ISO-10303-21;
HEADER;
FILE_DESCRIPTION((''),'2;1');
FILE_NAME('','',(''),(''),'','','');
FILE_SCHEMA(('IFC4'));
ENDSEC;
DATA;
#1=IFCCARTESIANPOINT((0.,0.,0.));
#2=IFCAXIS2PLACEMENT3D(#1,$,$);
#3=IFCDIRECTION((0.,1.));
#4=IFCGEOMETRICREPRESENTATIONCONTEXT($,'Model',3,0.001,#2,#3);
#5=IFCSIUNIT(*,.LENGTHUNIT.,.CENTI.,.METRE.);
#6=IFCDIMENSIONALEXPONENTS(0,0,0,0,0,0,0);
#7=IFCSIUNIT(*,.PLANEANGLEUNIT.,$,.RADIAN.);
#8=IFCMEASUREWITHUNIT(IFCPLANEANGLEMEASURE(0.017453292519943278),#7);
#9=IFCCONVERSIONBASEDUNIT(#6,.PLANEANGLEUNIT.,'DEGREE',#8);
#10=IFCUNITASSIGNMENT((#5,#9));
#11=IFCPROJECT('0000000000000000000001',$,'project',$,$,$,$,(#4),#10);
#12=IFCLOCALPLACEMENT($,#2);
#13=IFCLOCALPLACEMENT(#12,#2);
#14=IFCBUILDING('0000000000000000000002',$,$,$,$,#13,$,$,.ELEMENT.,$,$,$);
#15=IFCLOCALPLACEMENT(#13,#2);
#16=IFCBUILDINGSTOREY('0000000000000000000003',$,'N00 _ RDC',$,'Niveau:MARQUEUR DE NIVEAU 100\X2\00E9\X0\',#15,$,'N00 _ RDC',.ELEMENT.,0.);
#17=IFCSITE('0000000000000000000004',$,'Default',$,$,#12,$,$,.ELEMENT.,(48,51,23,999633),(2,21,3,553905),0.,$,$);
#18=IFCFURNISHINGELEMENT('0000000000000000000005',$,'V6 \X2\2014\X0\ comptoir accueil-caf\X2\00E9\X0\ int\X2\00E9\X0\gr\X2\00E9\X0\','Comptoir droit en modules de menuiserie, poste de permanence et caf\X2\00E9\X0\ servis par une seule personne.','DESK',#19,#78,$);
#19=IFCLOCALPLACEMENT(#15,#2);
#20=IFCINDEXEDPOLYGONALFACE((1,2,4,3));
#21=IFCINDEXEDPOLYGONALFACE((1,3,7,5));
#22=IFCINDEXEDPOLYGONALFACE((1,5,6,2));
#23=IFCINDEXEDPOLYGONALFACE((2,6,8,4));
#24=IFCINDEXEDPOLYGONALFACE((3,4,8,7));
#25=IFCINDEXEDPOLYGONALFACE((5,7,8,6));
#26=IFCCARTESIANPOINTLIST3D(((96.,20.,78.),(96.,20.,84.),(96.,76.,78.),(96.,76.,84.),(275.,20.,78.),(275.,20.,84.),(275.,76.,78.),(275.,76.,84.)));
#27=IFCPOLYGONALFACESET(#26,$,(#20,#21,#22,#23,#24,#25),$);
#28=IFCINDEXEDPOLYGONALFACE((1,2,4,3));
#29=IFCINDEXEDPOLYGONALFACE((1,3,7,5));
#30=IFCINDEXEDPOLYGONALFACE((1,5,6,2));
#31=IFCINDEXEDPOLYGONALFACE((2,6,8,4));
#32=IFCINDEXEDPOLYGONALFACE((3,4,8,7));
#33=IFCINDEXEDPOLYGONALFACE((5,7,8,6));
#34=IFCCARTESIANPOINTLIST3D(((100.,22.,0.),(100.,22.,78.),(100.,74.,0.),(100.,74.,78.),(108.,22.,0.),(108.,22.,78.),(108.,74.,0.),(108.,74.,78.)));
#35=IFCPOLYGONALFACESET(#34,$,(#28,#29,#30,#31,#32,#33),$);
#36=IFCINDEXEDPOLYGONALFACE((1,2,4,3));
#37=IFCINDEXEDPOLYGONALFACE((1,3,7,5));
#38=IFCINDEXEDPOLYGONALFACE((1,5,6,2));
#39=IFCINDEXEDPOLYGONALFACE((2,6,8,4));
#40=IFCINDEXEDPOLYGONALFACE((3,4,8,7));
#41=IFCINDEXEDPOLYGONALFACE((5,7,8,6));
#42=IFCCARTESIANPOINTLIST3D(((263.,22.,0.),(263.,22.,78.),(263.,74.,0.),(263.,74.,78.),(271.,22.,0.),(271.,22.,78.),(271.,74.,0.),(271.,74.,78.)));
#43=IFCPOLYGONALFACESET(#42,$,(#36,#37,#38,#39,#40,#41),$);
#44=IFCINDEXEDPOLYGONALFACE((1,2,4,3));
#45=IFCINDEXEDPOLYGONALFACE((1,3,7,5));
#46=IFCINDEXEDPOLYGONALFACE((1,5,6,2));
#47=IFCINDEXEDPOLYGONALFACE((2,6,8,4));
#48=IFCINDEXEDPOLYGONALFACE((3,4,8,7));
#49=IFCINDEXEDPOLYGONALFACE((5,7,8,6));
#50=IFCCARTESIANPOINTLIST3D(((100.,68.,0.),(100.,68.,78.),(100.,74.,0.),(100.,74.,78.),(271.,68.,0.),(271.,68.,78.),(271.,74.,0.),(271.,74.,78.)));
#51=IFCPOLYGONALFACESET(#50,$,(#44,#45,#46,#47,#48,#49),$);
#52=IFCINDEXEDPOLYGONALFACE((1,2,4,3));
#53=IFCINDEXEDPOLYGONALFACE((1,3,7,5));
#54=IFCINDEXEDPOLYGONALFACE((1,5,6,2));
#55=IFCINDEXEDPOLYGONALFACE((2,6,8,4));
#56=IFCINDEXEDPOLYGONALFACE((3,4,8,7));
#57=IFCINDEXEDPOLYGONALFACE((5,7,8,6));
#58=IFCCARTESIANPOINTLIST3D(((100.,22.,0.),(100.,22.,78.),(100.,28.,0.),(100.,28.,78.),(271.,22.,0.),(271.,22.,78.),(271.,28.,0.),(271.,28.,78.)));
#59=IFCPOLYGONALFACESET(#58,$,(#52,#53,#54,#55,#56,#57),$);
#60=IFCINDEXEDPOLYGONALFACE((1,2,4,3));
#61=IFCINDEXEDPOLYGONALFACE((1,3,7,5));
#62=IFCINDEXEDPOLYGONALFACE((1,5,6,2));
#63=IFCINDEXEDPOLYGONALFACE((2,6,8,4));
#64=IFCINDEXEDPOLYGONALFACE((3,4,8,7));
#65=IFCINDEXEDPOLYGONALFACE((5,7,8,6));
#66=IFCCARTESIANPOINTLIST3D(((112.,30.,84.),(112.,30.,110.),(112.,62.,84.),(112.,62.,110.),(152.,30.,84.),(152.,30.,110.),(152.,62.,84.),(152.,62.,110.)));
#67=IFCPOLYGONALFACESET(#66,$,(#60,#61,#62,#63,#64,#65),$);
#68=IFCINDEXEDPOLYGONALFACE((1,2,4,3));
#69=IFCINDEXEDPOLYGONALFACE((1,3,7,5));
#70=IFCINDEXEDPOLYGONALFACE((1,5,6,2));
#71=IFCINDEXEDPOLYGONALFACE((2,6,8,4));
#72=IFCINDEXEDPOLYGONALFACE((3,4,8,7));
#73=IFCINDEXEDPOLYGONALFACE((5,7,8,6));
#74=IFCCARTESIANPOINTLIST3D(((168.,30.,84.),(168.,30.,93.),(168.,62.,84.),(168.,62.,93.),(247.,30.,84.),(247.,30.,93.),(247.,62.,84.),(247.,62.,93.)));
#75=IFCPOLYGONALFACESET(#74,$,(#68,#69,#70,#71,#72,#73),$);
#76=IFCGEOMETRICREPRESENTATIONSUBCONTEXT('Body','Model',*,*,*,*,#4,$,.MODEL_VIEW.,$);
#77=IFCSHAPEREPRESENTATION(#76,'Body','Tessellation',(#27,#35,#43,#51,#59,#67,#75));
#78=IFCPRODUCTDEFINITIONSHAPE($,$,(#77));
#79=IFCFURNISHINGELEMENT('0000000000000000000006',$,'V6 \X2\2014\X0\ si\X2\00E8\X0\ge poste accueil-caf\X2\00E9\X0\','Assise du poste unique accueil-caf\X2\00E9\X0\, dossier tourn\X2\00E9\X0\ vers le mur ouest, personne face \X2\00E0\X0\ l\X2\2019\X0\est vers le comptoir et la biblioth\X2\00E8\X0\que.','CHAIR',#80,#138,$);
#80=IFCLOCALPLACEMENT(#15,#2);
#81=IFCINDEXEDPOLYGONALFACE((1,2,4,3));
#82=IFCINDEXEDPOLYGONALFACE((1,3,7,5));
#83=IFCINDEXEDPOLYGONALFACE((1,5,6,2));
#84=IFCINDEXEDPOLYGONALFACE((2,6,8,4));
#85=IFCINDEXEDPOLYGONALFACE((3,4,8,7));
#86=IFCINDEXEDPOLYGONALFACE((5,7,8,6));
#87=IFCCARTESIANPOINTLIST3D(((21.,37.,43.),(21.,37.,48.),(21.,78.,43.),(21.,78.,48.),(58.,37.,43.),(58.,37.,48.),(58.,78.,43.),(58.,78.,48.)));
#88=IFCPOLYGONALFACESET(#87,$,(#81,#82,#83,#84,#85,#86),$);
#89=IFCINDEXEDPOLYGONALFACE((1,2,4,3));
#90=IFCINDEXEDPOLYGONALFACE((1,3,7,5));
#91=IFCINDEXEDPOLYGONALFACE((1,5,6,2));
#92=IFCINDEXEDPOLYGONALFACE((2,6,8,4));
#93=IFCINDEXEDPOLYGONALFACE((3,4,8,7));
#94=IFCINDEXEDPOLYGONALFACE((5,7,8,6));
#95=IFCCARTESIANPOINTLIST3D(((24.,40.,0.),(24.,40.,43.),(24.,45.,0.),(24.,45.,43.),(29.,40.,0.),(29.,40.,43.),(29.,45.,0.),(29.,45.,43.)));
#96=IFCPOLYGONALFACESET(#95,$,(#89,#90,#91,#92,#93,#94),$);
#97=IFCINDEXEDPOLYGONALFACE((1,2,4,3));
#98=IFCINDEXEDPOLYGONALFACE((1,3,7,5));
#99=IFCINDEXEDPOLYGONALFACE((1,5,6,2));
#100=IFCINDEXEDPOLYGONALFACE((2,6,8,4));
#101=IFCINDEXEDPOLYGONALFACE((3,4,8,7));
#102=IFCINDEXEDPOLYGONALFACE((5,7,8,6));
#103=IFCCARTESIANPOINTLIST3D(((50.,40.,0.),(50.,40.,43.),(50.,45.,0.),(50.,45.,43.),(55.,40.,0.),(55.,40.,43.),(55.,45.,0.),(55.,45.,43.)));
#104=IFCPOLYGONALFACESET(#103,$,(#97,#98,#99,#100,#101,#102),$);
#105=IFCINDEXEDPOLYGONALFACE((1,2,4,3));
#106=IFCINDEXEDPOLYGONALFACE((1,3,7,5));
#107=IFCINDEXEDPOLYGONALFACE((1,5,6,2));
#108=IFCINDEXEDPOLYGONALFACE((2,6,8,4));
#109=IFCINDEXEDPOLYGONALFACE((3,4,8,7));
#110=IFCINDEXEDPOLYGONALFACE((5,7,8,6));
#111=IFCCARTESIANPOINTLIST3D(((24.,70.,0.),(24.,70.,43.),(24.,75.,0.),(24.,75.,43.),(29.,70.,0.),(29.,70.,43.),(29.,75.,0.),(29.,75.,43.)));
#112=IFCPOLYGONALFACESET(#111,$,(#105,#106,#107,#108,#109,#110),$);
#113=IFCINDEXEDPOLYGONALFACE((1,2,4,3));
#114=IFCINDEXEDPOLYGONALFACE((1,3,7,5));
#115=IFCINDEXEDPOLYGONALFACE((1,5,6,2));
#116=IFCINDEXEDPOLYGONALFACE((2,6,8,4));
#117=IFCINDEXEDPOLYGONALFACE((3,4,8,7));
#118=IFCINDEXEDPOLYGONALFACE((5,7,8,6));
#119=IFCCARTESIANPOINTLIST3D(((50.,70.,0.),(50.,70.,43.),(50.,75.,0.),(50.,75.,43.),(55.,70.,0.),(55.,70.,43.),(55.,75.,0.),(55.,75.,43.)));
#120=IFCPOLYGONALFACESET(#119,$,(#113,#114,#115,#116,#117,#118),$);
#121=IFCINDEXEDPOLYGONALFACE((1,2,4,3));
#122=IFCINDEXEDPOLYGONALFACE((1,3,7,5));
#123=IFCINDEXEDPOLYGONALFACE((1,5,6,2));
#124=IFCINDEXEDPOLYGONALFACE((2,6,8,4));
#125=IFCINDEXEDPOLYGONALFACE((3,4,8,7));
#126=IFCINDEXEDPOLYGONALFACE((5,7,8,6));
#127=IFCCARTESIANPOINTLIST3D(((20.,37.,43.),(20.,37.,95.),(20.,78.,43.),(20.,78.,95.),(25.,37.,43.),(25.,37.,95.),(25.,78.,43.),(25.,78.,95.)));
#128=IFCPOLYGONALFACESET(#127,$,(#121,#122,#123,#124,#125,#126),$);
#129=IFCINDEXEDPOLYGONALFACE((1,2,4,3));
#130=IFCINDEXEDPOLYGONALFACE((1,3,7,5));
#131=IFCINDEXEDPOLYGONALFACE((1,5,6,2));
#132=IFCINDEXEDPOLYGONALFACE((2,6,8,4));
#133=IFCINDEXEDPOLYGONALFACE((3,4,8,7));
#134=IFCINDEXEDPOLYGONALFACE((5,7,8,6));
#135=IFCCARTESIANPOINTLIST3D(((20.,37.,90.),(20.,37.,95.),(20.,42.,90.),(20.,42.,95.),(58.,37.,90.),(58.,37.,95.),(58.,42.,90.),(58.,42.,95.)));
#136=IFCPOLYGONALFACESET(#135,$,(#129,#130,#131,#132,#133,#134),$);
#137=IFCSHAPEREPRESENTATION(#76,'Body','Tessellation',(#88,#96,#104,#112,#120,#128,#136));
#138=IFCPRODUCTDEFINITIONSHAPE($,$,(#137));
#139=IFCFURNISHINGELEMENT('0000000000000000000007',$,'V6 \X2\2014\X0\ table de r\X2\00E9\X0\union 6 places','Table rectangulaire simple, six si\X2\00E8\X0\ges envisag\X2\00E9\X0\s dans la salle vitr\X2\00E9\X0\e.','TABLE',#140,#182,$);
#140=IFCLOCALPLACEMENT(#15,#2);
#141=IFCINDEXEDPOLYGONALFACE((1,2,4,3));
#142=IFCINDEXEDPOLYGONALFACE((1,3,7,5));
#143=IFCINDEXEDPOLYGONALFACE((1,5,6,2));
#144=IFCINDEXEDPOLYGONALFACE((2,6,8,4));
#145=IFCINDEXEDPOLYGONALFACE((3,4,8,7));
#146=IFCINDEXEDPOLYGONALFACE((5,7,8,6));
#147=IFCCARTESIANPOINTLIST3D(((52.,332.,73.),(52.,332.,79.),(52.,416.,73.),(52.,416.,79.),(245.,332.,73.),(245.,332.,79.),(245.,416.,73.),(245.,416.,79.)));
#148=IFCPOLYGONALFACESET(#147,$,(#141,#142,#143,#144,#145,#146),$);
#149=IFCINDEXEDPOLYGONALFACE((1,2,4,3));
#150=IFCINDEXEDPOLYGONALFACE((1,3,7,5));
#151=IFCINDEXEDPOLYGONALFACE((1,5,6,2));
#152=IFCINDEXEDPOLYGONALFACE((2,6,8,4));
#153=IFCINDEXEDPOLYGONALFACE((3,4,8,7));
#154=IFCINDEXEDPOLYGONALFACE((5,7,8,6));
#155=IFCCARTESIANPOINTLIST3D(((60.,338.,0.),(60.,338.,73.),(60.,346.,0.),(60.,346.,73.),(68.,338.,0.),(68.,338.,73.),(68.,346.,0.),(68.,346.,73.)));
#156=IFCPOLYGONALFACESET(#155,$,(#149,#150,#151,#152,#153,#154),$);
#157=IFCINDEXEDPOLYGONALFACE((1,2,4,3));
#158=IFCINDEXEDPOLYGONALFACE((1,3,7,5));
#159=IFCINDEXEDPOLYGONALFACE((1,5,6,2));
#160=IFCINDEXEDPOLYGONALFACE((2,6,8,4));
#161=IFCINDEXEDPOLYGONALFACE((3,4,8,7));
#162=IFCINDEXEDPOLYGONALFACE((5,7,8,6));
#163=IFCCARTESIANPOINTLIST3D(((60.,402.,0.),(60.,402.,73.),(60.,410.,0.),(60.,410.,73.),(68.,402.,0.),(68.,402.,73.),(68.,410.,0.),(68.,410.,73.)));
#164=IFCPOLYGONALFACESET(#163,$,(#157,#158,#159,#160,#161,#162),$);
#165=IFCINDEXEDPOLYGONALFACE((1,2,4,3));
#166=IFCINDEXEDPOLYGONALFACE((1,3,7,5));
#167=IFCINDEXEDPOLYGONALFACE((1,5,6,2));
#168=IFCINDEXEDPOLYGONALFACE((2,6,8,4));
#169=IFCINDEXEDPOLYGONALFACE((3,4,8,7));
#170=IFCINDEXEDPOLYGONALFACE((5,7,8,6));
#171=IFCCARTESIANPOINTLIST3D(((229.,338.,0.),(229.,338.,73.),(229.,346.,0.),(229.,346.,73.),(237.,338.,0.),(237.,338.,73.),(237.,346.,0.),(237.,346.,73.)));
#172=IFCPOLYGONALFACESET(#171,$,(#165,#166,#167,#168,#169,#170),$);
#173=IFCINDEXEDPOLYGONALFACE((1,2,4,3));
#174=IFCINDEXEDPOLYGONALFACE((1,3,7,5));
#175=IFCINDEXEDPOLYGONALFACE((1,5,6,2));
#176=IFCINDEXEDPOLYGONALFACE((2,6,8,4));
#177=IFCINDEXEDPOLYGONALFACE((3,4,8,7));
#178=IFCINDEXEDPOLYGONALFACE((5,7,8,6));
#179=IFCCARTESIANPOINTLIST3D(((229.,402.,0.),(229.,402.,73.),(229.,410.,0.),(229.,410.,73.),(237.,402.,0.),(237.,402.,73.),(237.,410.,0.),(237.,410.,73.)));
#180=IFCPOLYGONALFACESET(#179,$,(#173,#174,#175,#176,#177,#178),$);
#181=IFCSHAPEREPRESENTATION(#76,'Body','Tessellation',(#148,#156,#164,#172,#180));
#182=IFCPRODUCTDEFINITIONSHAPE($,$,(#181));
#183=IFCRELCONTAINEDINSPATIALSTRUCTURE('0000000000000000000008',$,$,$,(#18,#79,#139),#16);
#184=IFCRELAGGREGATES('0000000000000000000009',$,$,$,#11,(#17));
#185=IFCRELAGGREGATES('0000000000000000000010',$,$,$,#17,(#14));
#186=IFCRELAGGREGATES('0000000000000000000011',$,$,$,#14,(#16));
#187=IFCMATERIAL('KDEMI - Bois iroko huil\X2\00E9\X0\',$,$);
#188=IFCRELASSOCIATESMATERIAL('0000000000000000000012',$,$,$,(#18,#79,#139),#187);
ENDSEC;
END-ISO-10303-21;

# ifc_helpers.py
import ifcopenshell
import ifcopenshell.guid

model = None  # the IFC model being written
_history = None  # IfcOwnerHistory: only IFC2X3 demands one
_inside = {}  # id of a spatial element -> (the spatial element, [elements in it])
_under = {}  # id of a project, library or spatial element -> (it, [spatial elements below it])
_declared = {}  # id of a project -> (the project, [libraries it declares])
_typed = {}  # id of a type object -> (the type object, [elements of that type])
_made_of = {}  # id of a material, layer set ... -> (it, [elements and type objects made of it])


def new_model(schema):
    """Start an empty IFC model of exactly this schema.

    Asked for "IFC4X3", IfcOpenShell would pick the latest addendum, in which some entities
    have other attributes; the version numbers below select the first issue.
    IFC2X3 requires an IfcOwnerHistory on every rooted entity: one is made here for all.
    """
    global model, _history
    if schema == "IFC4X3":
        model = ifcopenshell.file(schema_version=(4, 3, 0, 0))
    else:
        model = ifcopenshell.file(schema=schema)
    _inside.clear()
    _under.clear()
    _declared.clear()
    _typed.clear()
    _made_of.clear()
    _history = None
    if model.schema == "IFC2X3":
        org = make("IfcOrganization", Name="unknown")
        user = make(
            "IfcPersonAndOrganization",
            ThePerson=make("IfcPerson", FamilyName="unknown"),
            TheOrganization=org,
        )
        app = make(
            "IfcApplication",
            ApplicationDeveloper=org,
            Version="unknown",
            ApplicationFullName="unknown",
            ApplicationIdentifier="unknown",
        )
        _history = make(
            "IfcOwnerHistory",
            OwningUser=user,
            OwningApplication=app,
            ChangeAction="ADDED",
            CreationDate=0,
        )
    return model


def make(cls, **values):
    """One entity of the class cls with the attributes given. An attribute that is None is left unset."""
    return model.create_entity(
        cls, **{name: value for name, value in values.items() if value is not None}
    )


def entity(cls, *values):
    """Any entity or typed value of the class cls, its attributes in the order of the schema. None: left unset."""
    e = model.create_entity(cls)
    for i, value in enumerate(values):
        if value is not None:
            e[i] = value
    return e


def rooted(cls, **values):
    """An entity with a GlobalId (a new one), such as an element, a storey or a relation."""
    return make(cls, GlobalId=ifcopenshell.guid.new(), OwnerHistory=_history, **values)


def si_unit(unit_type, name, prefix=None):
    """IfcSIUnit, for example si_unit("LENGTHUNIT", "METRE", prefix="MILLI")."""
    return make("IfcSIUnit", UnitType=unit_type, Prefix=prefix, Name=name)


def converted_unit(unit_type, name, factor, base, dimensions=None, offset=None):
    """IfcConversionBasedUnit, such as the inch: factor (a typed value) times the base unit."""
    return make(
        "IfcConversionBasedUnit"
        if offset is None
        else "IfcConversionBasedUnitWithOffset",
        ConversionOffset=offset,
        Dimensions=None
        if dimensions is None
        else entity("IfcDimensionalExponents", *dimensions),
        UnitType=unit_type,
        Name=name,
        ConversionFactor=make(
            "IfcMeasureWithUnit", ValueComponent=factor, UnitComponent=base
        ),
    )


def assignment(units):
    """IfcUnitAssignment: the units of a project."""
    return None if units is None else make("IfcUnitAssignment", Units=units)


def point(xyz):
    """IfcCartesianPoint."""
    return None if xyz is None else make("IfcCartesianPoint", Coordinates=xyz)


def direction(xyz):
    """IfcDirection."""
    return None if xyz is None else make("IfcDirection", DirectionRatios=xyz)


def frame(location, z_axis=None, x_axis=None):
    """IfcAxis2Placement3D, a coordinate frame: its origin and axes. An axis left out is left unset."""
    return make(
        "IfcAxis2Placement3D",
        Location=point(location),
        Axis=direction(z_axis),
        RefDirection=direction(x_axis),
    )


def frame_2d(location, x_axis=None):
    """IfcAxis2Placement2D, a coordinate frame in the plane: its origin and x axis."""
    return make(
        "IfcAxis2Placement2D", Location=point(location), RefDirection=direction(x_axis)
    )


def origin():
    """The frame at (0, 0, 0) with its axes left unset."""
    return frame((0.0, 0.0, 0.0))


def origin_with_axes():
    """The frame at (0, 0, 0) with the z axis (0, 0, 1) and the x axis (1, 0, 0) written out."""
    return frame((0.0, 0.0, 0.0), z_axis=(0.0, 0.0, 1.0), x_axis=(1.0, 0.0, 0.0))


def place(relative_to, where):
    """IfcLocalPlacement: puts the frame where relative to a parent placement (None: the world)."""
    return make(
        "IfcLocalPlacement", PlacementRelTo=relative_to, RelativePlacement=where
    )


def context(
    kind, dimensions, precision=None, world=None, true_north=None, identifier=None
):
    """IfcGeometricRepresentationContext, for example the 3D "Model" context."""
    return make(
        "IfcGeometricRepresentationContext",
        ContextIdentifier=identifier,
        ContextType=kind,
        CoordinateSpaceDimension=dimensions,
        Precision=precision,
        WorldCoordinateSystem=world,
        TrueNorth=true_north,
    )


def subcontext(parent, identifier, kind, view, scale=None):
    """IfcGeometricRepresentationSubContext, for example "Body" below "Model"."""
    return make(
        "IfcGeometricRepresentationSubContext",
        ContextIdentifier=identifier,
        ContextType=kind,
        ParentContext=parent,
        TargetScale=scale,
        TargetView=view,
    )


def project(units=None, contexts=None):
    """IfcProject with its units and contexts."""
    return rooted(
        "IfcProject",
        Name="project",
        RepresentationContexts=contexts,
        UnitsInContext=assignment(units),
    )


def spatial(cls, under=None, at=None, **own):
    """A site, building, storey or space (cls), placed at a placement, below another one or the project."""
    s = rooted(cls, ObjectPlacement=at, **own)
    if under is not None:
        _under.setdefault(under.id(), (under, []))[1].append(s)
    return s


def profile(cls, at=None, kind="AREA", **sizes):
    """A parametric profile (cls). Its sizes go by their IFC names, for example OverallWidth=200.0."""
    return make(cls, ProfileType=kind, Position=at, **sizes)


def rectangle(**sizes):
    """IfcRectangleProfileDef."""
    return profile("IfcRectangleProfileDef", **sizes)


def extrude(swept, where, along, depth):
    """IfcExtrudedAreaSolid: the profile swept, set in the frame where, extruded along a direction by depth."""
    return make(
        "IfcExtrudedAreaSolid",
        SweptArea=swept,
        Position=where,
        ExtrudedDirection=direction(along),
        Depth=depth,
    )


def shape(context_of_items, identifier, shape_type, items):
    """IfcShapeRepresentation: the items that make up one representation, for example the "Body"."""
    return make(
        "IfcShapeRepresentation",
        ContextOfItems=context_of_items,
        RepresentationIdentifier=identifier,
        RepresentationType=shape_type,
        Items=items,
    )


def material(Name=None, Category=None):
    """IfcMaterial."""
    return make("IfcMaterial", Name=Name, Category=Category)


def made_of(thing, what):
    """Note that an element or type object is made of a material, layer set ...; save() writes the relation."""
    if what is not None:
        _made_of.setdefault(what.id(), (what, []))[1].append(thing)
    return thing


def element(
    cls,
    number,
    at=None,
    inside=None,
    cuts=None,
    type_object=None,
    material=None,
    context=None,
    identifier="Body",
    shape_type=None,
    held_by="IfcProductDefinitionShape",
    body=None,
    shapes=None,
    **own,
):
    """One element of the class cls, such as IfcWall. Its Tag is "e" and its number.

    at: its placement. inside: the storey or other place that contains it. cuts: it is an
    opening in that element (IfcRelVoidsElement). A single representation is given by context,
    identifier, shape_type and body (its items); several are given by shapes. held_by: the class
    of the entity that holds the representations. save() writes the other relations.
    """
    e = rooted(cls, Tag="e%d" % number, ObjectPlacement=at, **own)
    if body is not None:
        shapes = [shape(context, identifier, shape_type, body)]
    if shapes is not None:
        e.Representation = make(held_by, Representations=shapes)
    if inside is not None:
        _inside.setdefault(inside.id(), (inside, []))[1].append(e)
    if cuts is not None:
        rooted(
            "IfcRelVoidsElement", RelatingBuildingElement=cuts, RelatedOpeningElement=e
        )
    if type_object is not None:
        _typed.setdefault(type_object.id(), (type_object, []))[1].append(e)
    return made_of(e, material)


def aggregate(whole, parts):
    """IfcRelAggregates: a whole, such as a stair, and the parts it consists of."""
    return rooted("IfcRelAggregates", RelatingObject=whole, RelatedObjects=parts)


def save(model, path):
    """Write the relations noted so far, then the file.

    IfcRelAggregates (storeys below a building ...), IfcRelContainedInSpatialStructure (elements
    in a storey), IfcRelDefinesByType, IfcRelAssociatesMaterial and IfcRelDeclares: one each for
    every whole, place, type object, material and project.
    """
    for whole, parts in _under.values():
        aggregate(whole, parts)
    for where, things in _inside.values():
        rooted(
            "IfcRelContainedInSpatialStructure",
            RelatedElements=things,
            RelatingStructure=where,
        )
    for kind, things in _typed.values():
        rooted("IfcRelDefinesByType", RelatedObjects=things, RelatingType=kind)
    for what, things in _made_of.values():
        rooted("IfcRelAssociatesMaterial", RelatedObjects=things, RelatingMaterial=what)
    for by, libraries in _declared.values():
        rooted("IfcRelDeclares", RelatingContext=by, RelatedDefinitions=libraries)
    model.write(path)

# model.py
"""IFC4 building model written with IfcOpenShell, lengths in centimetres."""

from ifc_helpers import new_model, entity, si_unit, converted_unit, direction, frame, frame_2d, origin, origin_with_axes, place, context, subcontext, project, spatial, rectangle, extrude, material, element, save


model = new_model("IFC4")

# Units and contexts
model_context = context("Model", 3, precision=0.001, world=origin(), true_north=direction((0.0, 1.0)))
body_context = subcontext(model_context, "Body", "Model", "MODEL_VIEW")
ifc_project = project(units=[si_unit("LENGTHUNIT", "METRE", prefix="CENTI"), converted_unit("PLANEANGLEUNIT", "DEGREE", entity("IfcPlaneAngleMeasure", 0.017453292519943278), si_unit("PLANEANGLEUNIT", "RADIAN"), dimensions=[0, 0, 0, 0, 0, 0, 0])], contexts=[model_context])

# Site, building, storey
site_placement = place(None, origin())
site = spatial("IfcSite", under=ifc_project, at=site_placement, Name="Default", CompositionType="ELEMENT", RefLatitude=(48, 51, 23, 999633), RefLongitude=(2, 21, 3, 553905), RefElevation=0.0)
building_placement = place(site_placement, origin())
building = spatial("IfcBuilding", under=site, at=building_placement, CompositionType="ELEMENT")
storey_placement = place(building_placement, origin())
storey = spatial("IfcBuildingStorey", under=building, at=storey_placement, Name="N00 _ RDC", ObjectType="Niveau:MARQUEUR DE NIVEAU 100é", LongName="N00 _ RDC", CompositionType="ELEMENT", Elevation=0.0)

# Furnishing elements
ifc_material_1 = material(Name="KDEMI - Bois iroko huilé")
furnishing_1_placement = place(storey_placement, origin_with_axes())
element("IfcFurnishingElement", 1, at=furnishing_1_placement, inside=storey, material=ifc_material_1, Name="V6 — comptoir accueil-café intégré", Description="Comptoir droit en modules de menuiserie, poste de permanence et café servis par une seule personne.", ObjectType="DESK", context=body_context, shape_type="SweptSolid", body=[
    extrude(rectangle(XDim=179.0, YDim=56.0, at=frame_2d((185.5, 48.0))), frame((0.0, 0.0, 78.0)), (0.0, 0.0, 1.0), 6.0),
    extrude(rectangle(XDim=8.0, YDim=52.0, at=frame_2d((104.0, 48.0))), origin(), (0.0, 0.0, 1.0), 78.0),
    extrude(rectangle(XDim=8.0, YDim=52.0, at=frame_2d((267.0, 48.0))), origin(), (0.0, 0.0, 1.0), 78.0),
    extrude(rectangle(XDim=171.0, YDim=6.0, at=frame_2d((185.5, 71.0))), origin(), (0.0, 0.0, 1.0), 78.0),
    extrude(rectangle(XDim=171.0, YDim=6.0, at=frame_2d((185.5, 25.0))), origin(), (0.0, 0.0, 1.0), 78.0),
    extrude(rectangle(XDim=40.0, YDim=32.0, at=frame_2d((132.0, 46.0))), frame((0.0, 0.0, 84.0)), (0.0, 0.0, 1.0), 26.0),
    extrude(rectangle(XDim=79.0, YDim=32.0, at=frame_2d((207.5, 46.0))), frame((0.0, 0.0, 84.0)), (0.0, 0.0, 1.0), 9.0),
])
furnishing_2_placement = place(storey_placement, origin_with_axes())
element("IfcFurnishingElement", 2, at=furnishing_2_placement, inside=storey, material=ifc_material_1, Name="V6 — siège poste accueil-café", Description="Assise du poste unique accueil-café, dossier tourné vers le mur ouest, personne face à l’est vers le comptoir et la bibliothèque.", ObjectType="CHAIR", context=body_context, shape_type="SweptSolid", body=[
    extrude(rectangle(XDim=37.0, YDim=41.0, at=frame_2d((39.5, 57.5))), frame((0.0, 0.0, 43.0)), (0.0, 0.0, 1.0), 5.0),
    extrude(rectangle(XDim=5.0, YDim=5.0, at=frame_2d((26.5, 42.5))), origin(), (0.0, 0.0, 1.0), 43.0),
    extrude(rectangle(XDim=5.0, YDim=5.0, at=frame_2d((52.5, 42.5))), origin(), (0.0, 0.0, 1.0), 43.0),
    extrude(rectangle(XDim=5.0, YDim=5.0, at=frame_2d((26.5, 72.5))), origin(), (0.0, 0.0, 1.0), 43.0),
    extrude(rectangle(XDim=5.0, YDim=5.0, at=frame_2d((52.5, 72.5))), origin(), (0.0, 0.0, 1.0), 43.0),
    extrude(rectangle(XDim=5.0, YDim=41.0, at=frame_2d((22.5, 57.5))), frame((0.0, 0.0, 43.0)), (0.0, 0.0, 1.0), 52.0),
    extrude(rectangle(XDim=38.0, YDim=5.0, at=frame_2d((39.0, 39.5))), frame((0.0, 0.0, 90.0)), (0.0, 0.0, 1.0), 5.0),
])
furnishing_3_placement = place(storey_placement, origin_with_axes())
element("IfcFurnishingElement", 3, at=furnishing_3_placement, inside=storey, material=ifc_material_1, Name="V6 — table de réunion 6 places", Description="Table rectangulaire simple, six sièges envisagés dans la salle vitrée.", ObjectType="TABLE", context=body_context, shape_type="SweptSolid", body=[
    extrude(rectangle(XDim=193.0, YDim=84.0, at=frame_2d((148.5, 374.0))), frame((0.0, 0.0, 73.0)), (0.0, 0.0, 1.0), 6.0),
    extrude(rectangle(XDim=8.0, YDim=8.0, at=frame_2d((64.0, 342.0))), origin(), (0.0, 0.0, 1.0), 73.0),
    extrude(rectangle(XDim=8.0, YDim=8.0, at=frame_2d((64.0, 406.0))), origin(), (0.0, 0.0, 1.0), 73.0),
    extrude(rectangle(XDim=8.0, YDim=8.0, at=frame_2d((233.0, 342.0))), origin(), (0.0, 0.0, 1.0), 73.0),
    extrude(rectangle(XDim=8.0, YDim=8.0, at=frame_2d((233.0, 406.0))), origin(), (0.0, 0.0, 1.0), 73.0),
])

save(model, "model.ifc")
